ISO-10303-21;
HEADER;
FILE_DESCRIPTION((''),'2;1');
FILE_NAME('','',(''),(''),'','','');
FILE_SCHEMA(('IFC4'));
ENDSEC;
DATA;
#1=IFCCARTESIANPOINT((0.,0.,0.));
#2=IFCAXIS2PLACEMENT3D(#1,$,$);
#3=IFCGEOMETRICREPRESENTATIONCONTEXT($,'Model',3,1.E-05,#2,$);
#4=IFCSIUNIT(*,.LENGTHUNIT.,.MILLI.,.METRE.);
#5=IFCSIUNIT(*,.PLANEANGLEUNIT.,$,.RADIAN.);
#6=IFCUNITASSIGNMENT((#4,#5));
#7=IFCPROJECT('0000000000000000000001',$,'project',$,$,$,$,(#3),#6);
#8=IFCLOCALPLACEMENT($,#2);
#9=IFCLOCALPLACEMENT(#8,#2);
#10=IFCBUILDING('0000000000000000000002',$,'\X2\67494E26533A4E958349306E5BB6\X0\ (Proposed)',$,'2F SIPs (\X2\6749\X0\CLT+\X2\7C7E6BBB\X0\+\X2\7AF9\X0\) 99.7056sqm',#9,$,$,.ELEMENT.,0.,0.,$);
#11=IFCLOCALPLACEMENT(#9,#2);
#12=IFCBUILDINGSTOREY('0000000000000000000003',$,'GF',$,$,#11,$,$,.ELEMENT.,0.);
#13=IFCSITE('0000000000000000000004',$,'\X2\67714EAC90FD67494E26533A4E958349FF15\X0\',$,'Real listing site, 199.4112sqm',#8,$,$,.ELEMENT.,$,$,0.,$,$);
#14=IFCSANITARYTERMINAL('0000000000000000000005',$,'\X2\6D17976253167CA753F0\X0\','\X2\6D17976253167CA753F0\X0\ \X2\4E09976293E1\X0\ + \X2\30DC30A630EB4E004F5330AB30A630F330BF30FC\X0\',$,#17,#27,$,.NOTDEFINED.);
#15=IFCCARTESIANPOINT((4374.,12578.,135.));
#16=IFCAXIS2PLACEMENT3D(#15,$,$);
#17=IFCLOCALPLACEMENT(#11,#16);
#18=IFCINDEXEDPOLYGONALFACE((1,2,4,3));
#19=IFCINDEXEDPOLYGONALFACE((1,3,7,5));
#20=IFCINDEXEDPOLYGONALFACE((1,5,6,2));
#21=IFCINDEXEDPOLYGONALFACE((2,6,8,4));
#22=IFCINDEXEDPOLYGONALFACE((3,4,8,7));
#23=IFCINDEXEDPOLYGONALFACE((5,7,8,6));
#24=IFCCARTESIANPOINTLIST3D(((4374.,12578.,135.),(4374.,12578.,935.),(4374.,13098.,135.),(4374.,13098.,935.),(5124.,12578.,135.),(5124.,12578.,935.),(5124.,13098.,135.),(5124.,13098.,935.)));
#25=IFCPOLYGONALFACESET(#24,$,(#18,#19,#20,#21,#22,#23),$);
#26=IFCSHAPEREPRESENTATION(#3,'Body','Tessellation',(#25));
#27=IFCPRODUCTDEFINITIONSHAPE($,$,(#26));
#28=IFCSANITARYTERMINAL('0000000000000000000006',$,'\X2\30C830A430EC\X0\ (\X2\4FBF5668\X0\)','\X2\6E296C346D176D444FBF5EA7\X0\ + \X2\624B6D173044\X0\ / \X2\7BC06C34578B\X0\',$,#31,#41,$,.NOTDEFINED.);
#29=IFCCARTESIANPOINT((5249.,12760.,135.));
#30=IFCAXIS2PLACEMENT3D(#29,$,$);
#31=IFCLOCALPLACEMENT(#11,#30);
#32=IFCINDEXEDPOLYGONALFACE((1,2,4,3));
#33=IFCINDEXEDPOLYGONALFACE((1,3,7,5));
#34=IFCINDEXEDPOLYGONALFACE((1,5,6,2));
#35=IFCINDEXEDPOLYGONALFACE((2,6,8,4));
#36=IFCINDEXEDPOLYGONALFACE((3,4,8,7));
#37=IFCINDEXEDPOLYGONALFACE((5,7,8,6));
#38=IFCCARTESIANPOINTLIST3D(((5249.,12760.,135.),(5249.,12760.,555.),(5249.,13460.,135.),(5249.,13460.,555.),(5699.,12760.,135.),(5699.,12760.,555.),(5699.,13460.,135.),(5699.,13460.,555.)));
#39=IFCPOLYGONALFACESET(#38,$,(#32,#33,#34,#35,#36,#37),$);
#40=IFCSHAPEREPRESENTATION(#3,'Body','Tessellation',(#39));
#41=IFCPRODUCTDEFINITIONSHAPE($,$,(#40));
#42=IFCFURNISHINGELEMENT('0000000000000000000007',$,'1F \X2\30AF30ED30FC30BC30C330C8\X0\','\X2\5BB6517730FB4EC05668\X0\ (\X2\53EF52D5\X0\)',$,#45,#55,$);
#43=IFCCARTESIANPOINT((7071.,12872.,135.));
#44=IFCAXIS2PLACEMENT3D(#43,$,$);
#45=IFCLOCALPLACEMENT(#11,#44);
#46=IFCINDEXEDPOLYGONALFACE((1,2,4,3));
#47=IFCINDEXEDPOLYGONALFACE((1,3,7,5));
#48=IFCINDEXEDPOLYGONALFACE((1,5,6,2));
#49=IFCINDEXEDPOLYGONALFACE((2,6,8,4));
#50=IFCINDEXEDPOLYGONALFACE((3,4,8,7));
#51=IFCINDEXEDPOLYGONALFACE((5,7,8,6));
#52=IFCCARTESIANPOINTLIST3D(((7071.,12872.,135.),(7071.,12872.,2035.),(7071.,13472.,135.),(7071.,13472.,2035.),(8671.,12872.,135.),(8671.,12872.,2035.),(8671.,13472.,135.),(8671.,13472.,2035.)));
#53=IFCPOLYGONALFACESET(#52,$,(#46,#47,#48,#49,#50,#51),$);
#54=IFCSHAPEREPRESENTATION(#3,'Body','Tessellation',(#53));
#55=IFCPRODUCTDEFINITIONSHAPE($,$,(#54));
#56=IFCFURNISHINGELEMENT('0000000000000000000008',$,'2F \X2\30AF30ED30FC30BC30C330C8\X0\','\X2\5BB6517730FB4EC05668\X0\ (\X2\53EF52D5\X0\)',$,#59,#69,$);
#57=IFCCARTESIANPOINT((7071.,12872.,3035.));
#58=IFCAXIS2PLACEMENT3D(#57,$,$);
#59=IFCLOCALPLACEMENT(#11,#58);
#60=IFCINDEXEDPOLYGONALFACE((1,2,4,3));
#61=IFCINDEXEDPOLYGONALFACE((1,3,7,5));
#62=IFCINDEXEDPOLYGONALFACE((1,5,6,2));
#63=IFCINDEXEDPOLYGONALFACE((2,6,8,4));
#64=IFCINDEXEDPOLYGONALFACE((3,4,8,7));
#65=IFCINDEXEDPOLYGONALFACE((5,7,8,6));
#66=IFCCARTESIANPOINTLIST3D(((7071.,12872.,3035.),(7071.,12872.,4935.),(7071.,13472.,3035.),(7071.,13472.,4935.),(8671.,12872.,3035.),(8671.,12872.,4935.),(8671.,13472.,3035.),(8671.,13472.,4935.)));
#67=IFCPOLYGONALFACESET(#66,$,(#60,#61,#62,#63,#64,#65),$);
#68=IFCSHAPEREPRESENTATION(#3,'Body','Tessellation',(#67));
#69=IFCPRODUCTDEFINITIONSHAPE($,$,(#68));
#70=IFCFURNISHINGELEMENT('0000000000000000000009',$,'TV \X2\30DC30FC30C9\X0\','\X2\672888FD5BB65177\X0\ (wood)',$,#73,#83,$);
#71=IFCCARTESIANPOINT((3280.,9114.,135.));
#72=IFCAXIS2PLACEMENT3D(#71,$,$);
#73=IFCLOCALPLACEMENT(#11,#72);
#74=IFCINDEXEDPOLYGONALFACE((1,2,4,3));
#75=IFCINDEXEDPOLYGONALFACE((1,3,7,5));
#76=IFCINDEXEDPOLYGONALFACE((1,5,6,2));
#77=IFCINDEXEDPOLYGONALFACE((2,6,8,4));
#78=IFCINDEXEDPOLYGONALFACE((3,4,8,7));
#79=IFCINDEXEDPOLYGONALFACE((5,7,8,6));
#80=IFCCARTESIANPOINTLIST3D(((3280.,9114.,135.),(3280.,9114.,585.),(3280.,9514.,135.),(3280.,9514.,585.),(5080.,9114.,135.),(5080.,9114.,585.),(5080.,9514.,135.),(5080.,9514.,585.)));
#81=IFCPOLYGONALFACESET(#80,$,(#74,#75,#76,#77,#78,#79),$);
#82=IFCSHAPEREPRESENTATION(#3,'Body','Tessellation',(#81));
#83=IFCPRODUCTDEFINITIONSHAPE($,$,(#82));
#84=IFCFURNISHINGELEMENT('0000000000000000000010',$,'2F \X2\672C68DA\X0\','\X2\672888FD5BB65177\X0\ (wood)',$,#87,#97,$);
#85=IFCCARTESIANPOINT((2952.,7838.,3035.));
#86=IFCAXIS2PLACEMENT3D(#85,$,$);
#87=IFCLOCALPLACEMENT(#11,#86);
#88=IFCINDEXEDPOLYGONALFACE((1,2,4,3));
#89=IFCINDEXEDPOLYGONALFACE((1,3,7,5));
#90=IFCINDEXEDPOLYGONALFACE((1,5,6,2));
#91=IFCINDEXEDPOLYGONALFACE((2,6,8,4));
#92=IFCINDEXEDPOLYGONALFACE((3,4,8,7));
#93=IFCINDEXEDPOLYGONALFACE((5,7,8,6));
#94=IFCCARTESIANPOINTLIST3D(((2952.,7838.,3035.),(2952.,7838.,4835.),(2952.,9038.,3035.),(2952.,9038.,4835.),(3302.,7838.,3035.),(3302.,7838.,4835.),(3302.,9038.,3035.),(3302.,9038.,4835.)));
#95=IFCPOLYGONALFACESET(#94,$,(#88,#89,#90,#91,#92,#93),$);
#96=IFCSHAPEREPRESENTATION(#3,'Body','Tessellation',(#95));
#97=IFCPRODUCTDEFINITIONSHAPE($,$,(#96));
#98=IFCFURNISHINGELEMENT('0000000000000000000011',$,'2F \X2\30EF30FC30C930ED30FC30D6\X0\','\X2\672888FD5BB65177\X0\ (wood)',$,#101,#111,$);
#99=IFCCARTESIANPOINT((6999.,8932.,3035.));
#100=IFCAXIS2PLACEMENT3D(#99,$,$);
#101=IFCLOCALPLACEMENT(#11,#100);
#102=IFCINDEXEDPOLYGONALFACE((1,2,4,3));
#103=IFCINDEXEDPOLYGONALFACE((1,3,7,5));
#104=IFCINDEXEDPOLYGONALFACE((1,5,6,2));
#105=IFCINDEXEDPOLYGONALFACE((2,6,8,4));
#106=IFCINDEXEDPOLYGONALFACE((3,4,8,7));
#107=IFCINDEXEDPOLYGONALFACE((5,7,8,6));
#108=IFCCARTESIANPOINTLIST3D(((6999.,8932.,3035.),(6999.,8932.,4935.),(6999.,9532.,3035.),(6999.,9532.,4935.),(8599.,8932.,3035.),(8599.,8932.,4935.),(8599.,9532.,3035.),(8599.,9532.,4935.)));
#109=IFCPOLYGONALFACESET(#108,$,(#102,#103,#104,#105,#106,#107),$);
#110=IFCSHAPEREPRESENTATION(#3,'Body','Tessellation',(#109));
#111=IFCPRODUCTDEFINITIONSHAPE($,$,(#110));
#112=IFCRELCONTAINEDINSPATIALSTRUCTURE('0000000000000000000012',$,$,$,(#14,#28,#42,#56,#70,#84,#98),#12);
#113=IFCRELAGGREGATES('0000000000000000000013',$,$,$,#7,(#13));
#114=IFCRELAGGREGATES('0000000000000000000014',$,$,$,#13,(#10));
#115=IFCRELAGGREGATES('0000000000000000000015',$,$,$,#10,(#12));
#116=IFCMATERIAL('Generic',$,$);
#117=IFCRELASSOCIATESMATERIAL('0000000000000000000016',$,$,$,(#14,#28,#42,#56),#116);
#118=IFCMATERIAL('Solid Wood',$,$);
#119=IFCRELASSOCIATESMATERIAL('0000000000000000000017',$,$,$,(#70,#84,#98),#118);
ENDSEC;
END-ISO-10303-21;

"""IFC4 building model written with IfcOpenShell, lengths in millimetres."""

from ifc_helpers import new_model, si_unit, frame, frame_2d, origin, place, context, project, spatial, rectangle, extrude, material, element, save


model = new_model("IFC4")

# Units and contexts
model_context = context("Model", 3, precision=1e-05, world=origin())
ifc_project = project(units=[si_unit("LENGTHUNIT", "METRE", prefix="MILLI"), si_unit("PLANEANGLEUNIT", "RADIAN")], contexts=[model_context])

# Site, building, storey
site_placement = place(None, origin())
site = spatial("IfcSite", under=ifc_project, at=site_placement, Name="東京都杉並区井草５", ObjectType="Real listing site, 199.4112sqm", CompositionType="ELEMENT", RefElevation=0.0)
building_placement = place(site_placement, origin())
building = spatial("IfcBuilding", under=site, at=building_placement, Name="杉並区井草の家 (Proposed)", ObjectType="2F SIPs (杉CLT+籾殻+竹) 99.7056sqm", CompositionType="ELEMENT", ElevationOfRefHeight=0.0, ElevationOfTerrain=0.0)
storey_placement = place(building_placement, origin())
storey = spatial("IfcBuildingStorey", under=building, at=storey_placement, Name="GF", CompositionType="ELEMENT", Elevation=0.0)

# Shared definitions
ifc_material_1 = material(Name="Solid Wood")

# Sanitary terminals
ifc_material_2 = material(Name="Generic")
sanitary_terminal_1_placement = place(storey_placement, frame((4374.0, 12578.0, 135.0)))
element("IfcSanitaryTerminal", 1, at=sanitary_terminal_1_placement, inside=storey, material=ifc_material_2, Name="洗面化粧台", Description="洗面化粧台 三面鏡 + ボウル一体カウンター", PredefinedType="NOTDEFINED", context=model_context, shape_type="SweptSolid", body=[
    extrude(rectangle(XDim=750.0, YDim=520.0, at=frame_2d((375.0, 260.0))), frame((4374.0, 12578.0, 135.0)), (0.0, 0.0, 1.0), 800.0),
])
sanitary_terminal_2_placement = place(storey_placement, frame((5249.0, 12760.0, 135.0)))
element("IfcSanitaryTerminal", 2, at=sanitary_terminal_2_placement, inside=storey, material=ifc_material_2, Name="トイレ (便器)", Description="温水洗浄便座 + 手洗い / 節水型", PredefinedType="NOTDEFINED", context=model_context, shape_type="SweptSolid", body=[
    extrude(rectangle(XDim=450.0, YDim=700.0, at=frame_2d((225.0, 350.0))), frame((5249.0, 12760.0, 135.0)), (0.0, 0.0, 1.0), 420.0),
])

# Furnishing elements
furnishing_1_placement = place(storey_placement, frame((7071.0, 12872.0, 135.0)))
element("IfcFurnishingElement", 3, at=furnishing_1_placement, inside=storey, material=ifc_material_2, Name="1F クローゼット", Description="家具・什器 (可動)", context=model_context, shape_type="SweptSolid", body=[
    extrude(rectangle(XDim=1600.0, YDim=600.0, at=frame_2d((800.0, 300.0))), frame((7071.0, 12872.0, 135.0)), (0.0, 0.0, 1.0), 1900.0),
])
furnishing_2_placement = place(storey_placement, frame((7071.0, 12872.0, 3035.0)))
element("IfcFurnishingElement", 4, at=furnishing_2_placement, inside=storey, material=ifc_material_2, Name="2F クローゼット", Description="家具・什器 (可動)", context=model_context, shape_type="SweptSolid", body=[
    extrude(rectangle(XDim=1600.0, YDim=600.0, at=frame_2d((800.0, 300.0))), frame((7071.0, 12872.0, 3035.0)), (0.0, 0.0, 1.0), 1900.0),
])
furnishing_3_placement = place(storey_placement, frame((3280.0, 9114.0, 135.0)))
element("IfcFurnishingElement", 5, at=furnishing_3_placement, inside=storey, material=ifc_material_1, Name="TV ボード", Description="木製家具 (wood)", context=model_context, shape_type="SweptSolid", body=[
    extrude(rectangle(XDim=1800.0, YDim=400.0, at=frame_2d((900.0, 200.0))), frame((3280.0, 9114.0, 135.0)), (0.0, 0.0, 1.0), 450.0),
])
furnishing_4_placement = place(storey_placement, frame((2952.0, 7838.0, 3035.0)))
element("IfcFurnishingElement", 6, at=furnishing_4_placement, inside=storey, material=ifc_material_1, Name="2F 本棚", Description="木製家具 (wood)", context=model_context, shape_type="SweptSolid", body=[
    extrude(rectangle(XDim=350.0, YDim=1200.0, at=frame_2d((175.0, 600.0))), frame((2952.0, 7838.0, 3035.0)), (0.0, 0.0, 1.0), 1800.0),
])
furnishing_5_placement = place(storey_placement, frame((6999.0, 8932.0, 3035.0)))
element("IfcFurnishingElement", 7, at=furnishing_5_placement, inside=storey, material=ifc_material_1, Name="2F ワードローブ", Description="木製家具 (wood)", context=model_context, shape_type="SweptSolid", body=[
    extrude(rectangle(XDim=1600.0, YDim=600.0, at=frame_2d((800.0, 300.0))), frame((6999.0, 8932.0, 3035.0)), (0.0, 0.0, 1.0), 1900.0),
])

save(model, "model.ifc")
